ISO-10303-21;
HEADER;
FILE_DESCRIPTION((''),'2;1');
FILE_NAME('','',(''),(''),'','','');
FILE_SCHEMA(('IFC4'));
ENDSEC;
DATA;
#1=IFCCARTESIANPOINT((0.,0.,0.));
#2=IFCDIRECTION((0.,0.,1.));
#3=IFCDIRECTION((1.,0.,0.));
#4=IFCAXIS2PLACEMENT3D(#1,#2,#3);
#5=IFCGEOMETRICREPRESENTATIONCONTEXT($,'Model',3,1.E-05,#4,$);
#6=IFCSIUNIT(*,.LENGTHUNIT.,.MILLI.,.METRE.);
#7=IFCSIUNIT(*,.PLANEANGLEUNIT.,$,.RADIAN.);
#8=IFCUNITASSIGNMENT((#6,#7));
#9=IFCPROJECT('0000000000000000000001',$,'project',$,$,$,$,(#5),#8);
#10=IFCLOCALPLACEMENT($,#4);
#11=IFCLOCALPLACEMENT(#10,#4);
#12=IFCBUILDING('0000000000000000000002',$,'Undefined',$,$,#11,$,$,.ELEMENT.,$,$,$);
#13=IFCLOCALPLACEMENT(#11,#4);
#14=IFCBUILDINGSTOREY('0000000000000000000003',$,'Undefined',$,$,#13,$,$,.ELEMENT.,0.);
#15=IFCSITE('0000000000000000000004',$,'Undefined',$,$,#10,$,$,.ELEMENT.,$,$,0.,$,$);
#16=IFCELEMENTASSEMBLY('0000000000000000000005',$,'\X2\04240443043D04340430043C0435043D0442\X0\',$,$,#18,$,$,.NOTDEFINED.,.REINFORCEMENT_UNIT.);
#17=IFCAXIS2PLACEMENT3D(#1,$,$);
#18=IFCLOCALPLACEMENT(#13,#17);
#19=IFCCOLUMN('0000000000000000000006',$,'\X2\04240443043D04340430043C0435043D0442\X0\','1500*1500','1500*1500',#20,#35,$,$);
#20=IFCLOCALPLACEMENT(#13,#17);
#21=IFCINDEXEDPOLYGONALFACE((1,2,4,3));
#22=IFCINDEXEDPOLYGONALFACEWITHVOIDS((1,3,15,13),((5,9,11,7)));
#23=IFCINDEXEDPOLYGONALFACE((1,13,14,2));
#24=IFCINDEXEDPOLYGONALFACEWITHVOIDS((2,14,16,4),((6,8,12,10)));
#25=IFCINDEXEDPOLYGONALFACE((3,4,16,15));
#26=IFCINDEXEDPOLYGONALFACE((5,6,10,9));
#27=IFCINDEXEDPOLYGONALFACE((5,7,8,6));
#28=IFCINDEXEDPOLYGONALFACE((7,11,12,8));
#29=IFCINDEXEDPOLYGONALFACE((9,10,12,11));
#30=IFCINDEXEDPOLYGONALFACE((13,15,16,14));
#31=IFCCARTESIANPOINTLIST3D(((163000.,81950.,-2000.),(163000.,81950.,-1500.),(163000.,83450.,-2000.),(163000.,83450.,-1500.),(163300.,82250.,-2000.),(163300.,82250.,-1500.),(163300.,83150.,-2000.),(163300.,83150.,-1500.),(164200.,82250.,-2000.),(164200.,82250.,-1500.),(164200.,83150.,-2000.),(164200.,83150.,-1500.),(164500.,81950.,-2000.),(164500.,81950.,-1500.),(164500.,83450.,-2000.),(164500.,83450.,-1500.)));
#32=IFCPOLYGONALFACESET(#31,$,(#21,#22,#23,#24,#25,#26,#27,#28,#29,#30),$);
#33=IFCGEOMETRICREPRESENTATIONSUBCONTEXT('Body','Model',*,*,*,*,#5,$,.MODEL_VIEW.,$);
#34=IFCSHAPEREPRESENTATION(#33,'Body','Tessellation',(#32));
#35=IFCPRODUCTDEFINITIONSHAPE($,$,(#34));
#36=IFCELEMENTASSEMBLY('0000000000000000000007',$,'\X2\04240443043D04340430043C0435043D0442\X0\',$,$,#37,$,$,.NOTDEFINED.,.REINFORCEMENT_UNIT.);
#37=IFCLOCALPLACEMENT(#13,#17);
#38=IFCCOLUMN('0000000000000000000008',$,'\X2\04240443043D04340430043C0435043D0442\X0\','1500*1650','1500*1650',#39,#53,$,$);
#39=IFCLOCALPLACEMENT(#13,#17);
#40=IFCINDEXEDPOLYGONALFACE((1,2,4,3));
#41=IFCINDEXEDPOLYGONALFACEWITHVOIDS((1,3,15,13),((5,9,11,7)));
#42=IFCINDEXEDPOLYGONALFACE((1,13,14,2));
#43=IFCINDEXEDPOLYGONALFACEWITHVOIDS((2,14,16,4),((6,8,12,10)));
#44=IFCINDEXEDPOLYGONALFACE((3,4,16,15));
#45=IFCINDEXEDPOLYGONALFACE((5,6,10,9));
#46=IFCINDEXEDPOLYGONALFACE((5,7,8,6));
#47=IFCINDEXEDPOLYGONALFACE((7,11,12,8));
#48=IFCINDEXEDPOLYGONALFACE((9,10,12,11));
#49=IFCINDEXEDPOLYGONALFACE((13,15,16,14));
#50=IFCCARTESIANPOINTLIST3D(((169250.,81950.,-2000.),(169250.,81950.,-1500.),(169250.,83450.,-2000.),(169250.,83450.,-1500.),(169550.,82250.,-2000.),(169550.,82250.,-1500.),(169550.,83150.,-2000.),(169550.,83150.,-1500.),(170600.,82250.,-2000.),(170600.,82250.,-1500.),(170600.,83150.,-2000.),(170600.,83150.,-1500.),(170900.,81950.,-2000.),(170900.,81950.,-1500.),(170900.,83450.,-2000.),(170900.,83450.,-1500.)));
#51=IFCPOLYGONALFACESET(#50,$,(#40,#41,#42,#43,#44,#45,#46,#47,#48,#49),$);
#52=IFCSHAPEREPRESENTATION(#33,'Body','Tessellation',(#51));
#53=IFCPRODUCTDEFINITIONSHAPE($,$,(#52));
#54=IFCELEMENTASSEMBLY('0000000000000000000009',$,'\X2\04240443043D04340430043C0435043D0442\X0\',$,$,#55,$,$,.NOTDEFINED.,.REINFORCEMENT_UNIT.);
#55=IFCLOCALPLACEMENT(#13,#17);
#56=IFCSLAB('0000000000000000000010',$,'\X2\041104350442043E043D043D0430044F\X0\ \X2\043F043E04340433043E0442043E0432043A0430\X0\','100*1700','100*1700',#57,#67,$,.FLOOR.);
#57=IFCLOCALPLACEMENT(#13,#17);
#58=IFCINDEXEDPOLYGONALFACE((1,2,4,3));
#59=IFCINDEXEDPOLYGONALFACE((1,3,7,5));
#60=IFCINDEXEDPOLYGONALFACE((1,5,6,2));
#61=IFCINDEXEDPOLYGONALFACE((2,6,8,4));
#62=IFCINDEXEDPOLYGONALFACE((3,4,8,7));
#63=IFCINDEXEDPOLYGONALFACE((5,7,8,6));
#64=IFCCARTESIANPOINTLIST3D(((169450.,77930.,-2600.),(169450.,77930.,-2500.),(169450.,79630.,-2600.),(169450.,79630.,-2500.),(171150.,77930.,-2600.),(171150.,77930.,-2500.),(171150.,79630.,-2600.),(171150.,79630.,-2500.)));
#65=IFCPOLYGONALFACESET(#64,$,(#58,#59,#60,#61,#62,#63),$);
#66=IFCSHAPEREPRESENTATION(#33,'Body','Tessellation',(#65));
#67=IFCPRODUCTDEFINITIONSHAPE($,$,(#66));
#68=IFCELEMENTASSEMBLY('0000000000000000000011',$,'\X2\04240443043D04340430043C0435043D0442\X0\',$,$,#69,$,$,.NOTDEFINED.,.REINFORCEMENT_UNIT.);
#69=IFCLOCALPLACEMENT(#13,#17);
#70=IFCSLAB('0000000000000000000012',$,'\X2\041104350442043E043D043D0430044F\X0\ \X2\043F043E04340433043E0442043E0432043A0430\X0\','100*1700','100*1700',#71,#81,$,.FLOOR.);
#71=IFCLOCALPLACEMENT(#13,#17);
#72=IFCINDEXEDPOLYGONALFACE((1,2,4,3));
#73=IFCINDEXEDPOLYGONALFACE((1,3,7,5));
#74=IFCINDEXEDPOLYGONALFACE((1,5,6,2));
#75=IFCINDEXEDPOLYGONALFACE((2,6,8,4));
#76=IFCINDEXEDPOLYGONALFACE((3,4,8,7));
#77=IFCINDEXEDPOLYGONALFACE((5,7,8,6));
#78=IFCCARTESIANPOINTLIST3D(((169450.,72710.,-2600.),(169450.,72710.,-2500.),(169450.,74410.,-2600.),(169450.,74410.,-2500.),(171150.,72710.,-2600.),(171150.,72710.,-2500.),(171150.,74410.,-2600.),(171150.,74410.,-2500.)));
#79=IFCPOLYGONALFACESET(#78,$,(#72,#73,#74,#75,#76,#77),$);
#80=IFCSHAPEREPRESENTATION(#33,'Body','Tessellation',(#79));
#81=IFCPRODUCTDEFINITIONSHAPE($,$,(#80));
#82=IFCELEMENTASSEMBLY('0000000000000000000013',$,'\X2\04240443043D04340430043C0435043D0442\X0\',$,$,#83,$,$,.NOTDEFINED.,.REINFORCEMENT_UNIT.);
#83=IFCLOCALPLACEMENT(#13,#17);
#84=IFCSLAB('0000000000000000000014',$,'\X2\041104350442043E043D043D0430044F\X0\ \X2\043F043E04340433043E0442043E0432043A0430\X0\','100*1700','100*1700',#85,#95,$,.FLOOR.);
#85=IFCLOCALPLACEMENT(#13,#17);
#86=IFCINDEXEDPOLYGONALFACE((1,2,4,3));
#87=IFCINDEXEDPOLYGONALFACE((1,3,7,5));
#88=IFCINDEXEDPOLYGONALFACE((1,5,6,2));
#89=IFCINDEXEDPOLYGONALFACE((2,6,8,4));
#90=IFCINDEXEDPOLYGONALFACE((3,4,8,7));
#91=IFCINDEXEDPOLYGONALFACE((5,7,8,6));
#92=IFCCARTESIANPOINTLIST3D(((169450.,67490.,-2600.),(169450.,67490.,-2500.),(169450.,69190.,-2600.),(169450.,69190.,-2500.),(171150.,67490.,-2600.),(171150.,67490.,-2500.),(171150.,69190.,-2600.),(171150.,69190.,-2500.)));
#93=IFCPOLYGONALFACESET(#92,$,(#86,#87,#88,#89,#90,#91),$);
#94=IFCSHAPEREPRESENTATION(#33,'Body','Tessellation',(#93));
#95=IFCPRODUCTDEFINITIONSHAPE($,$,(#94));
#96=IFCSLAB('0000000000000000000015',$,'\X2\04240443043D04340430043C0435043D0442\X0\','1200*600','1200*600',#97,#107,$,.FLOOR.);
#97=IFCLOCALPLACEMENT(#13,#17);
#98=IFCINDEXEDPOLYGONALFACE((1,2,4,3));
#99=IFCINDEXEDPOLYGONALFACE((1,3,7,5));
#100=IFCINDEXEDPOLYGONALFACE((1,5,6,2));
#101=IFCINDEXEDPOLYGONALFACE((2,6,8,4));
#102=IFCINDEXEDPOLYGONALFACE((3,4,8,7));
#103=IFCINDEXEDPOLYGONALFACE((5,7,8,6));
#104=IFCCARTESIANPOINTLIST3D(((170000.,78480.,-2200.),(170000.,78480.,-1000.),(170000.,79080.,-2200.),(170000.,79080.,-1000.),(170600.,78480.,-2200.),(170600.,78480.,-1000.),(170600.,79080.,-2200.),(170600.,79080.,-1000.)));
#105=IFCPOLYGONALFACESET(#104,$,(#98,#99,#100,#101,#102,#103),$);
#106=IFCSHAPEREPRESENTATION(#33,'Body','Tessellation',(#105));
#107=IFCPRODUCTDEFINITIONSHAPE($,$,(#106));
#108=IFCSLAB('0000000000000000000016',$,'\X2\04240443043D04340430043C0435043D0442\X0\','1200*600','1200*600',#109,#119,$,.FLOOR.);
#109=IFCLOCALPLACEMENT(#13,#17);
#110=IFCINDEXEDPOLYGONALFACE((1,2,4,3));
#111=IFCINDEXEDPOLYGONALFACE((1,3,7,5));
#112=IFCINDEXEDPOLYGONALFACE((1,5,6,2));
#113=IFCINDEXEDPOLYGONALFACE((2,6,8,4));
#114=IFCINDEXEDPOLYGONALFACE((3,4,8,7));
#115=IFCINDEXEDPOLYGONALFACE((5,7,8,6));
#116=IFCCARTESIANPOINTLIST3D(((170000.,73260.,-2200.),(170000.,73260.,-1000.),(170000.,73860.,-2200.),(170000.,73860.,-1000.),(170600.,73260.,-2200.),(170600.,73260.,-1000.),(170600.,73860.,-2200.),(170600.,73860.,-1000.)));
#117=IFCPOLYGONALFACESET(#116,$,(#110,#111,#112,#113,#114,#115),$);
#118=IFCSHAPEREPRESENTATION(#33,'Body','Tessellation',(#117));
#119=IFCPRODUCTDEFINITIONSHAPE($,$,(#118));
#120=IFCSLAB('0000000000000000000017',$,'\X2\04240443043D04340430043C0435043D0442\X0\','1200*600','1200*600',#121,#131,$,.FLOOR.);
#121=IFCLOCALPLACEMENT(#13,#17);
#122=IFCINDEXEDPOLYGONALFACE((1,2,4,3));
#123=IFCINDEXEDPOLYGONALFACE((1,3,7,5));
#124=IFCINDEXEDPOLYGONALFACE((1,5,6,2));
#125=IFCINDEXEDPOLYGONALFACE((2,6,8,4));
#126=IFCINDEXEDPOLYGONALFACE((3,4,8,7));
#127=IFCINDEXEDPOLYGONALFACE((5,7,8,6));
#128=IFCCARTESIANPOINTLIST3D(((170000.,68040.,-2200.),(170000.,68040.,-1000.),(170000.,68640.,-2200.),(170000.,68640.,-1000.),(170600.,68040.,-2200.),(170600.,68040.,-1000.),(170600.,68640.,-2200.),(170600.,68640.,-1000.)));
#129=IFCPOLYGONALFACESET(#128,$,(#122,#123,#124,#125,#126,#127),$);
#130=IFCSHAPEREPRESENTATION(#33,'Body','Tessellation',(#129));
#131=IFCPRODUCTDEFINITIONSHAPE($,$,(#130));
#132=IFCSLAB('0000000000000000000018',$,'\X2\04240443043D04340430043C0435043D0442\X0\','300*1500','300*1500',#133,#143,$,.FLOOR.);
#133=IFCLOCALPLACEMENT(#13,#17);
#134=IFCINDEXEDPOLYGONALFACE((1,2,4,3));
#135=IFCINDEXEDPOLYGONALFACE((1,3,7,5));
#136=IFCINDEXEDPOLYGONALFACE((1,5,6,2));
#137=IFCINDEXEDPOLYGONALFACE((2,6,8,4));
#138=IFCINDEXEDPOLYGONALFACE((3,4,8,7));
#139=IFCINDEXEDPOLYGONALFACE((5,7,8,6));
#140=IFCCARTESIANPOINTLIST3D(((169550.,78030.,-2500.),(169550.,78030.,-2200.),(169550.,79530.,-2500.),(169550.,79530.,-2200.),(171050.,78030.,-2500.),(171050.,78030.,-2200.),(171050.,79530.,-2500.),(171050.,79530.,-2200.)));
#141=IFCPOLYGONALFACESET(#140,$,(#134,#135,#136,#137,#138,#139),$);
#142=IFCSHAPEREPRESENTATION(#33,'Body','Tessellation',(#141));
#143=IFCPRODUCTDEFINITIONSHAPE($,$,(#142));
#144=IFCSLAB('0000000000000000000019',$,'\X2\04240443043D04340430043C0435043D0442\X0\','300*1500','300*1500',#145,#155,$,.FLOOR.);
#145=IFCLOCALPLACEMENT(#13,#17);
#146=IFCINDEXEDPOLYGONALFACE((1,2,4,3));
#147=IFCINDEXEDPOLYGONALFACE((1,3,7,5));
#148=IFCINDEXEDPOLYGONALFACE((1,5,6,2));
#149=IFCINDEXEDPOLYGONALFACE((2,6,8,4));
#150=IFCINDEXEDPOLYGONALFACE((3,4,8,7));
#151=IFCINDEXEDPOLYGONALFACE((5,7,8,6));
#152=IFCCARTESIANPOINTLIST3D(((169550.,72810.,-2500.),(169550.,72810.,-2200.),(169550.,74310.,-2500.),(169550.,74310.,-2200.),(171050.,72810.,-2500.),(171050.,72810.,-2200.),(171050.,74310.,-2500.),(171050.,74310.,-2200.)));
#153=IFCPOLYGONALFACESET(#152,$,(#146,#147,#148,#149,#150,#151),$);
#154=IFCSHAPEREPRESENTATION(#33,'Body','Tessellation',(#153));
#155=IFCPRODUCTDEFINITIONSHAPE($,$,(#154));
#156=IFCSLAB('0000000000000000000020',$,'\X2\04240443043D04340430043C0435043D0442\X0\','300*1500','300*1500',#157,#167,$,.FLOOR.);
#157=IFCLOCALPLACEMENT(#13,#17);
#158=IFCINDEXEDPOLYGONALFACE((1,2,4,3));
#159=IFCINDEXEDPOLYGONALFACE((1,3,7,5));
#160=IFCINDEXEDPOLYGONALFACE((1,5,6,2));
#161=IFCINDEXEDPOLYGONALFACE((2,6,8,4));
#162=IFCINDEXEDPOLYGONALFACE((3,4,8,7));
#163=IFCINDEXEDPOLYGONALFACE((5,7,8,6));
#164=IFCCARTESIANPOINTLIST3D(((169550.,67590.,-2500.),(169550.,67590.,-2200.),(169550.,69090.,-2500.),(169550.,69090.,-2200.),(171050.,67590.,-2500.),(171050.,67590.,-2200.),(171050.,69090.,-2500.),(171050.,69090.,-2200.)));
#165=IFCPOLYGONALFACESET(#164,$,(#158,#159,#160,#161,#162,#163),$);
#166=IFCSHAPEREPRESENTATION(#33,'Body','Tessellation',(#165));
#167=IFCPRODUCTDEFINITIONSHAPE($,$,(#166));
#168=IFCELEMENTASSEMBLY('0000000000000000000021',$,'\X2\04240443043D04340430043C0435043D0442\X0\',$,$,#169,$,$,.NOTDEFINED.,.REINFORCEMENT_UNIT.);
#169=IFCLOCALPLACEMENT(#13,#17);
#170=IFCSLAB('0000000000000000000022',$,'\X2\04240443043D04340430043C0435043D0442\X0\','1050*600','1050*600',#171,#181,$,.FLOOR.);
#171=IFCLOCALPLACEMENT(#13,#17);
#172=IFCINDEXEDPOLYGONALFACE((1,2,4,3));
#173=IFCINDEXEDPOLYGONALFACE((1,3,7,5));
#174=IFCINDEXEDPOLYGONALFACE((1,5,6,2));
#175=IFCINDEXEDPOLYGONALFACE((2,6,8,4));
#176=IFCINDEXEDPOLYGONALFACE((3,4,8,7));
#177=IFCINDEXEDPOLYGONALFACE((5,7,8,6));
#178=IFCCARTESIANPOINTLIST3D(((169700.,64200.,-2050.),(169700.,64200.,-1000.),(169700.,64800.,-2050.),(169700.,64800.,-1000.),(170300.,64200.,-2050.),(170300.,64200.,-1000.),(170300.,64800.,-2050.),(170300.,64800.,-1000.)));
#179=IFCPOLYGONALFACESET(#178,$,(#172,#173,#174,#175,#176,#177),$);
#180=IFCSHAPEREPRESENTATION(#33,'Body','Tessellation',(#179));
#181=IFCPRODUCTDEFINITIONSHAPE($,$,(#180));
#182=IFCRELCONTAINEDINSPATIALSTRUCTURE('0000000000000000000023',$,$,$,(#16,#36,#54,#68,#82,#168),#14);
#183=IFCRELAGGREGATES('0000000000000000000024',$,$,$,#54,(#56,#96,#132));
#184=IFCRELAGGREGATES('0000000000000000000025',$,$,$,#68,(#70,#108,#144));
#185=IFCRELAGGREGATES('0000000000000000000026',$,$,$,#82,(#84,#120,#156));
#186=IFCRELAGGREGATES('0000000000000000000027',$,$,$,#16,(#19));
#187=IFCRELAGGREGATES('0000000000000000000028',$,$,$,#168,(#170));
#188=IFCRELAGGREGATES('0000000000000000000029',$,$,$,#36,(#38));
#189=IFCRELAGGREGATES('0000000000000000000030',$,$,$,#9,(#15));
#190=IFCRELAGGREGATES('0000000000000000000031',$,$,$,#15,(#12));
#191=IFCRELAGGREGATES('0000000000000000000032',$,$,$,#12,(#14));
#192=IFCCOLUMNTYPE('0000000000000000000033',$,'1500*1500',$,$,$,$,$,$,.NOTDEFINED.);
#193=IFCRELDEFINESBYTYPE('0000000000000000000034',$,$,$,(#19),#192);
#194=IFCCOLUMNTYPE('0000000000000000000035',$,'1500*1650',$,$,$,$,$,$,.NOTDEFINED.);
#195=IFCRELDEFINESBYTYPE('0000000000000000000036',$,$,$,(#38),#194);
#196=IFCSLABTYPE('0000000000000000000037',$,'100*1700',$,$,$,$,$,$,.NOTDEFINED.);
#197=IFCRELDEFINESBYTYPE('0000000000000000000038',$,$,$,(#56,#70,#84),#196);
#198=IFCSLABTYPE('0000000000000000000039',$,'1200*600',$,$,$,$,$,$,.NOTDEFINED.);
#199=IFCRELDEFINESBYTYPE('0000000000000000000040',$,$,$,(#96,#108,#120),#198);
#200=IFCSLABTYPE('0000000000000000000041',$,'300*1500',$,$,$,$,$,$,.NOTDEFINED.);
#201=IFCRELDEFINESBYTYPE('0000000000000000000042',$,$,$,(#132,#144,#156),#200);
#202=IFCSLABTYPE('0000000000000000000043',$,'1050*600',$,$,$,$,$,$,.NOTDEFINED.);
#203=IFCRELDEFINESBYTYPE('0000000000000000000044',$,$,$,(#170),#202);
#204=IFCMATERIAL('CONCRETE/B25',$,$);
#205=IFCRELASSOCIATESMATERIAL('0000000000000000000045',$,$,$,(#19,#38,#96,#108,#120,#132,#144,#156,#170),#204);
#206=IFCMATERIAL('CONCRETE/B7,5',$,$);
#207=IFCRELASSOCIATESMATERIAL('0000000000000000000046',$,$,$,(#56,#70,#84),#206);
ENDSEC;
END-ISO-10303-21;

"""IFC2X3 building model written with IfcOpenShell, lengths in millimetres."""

from ifc_helpers import new_model, si_unit, frame, origin_with_axes, origin_2d_with_axis, place, context, subcontext, project, spatial, polyline, rectangle, outline, extrude, boolean, material, type_object, element, aggregate, save


model = new_model("IFC2X3")

# Units and contexts
model_context = context("Model", 3, precision=1e-05, world=origin_with_axes())
body_context = subcontext(model_context, "Body", "Model", "MODEL_VIEW")
ifc_project = project(units=[si_unit("LENGTHUNIT", "METRE", prefix="MILLI"), si_unit("PLANEANGLEUNIT", "RADIAN")], contexts=[model_context])

# Site, building, storey
site_placement = place(None, origin_with_axes())
site = spatial("IfcSite", under=ifc_project, at=site_placement, Name="Undefined", CompositionType="ELEMENT", RefElevation=0.0)
building_placement = place(site_placement, origin_with_axes())
building = spatial("IfcBuilding", under=site, at=building_placement, Name="Undefined", CompositionType="ELEMENT")
storey_placement = place(building_placement, origin_with_axes())
storey = spatial("IfcBuildingStorey", under=building, at=storey_placement, Name="Undefined", CompositionType="ELEMENT", Elevation=0.0)

# Element assemblies, columns
assembly_1_placement = place(storey_placement, origin_with_axes())
assembly_1 = element("IfcElementAssembly", 1, at=assembly_1_placement, inside=storey, Name="Фундамент", AssemblyPlace="NOTDEFINED", PredefinedType="REINFORCEMENT_UNIT")
ifc_material_1 = material(Name="CONCRETE/B25")
column_type_1 = type_object("IfcColumnType", Name="1500*1500", PredefinedType="NOTDEFINED")
column_1_placement = place(assembly_1_placement, frame((163750.0, 82700.0, -2000.0), z_axis=(0.0, 0.0, 1.0), x_axis=(0.0, -1.0, 0.0)))
column_1 = element("IfcColumn", 2, at=column_1_placement, type_object=column_type_1, material=ifc_material_1, Name="Фундамент", Description="1500*1500", ObjectType="1500*1500", context=body_context, shape_type="CSG", body=[
    boolean("DIFFERENCE", extrude(rectangle(XDim=1500.0, YDim=1500.0, at=origin_2d_with_axis()), frame((0.0, 0.0, 500.0), z_axis=(0.0, 0.0, -1.0), x_axis=(0.0, 1.0, 0.0)), (0.0, 0.0, 1.0), 500.0), extrude(outline(polyline([(0.0, 0.0), (900.0, 0.0), (900.0, 900.0), (0.0, 900.0), (0.0, 0.0)])), frame((-450.0, -450.0, -100.0), z_axis=(0.0, 0.0, 1.0), x_axis=(1.0, 0.0, 0.0)), (0.0, 0.0, 1.0), 700.0)),
])
assembly_2_placement = place(storey_placement, origin_with_axes())
assembly_2 = element("IfcElementAssembly", 3, at=assembly_2_placement, inside=storey, Name="Фундамент", AssemblyPlace="NOTDEFINED", PredefinedType="REINFORCEMENT_UNIT")
column_type_2 = type_object("IfcColumnType", Name="1500*1650", PredefinedType="NOTDEFINED")
column_2_placement = place(assembly_2_placement, frame((170075.0, 82700.0, -2000.0), z_axis=(0.0, 0.0, 1.0), x_axis=(0.0, -1.0, 0.0)))
column_2 = element("IfcColumn", 4, at=column_2_placement, type_object=column_type_2, material=ifc_material_1, Name="Фундамент", Description="1500*1650", ObjectType="1500*1650", context=body_context, shape_type="CSG", body=[
    boolean("DIFFERENCE", extrude(rectangle(XDim=1650.0, YDim=1500.0, at=origin_2d_with_axis()), frame((0.0, 0.0, 500.0), z_axis=(0.0, 0.0, -1.0), x_axis=(0.0, 1.0, 0.0)), (0.0, 0.0, 1.0), 500.0), extrude(outline(polyline([(0.0, 0.0), (900.0, 0.0), (900.0, 1050.0), (0.0, 1050.0), (0.0, 0.0)])), frame((-450.0, -525.0, -100.0), z_axis=(0.0, 0.0, 1.0), x_axis=(1.0, 0.0, 0.0)), (0.0, 0.0, 1.0), 700.0)),
])

# Element assemblies, slabs
assembly_3_placement = place(storey_placement, origin_with_axes())
assembly_3 = element("IfcElementAssembly", 5, at=assembly_3_placement, inside=storey, Name="Фундамент", AssemblyPlace="NOTDEFINED", PredefinedType="REINFORCEMENT_UNIT")
ifc_material_2 = material(Name="CONCRETE/B7,5")
slab_type_1 = type_object("IfcSlabType", Name="100*1700", PredefinedType="NOTDEFINED")
slab_1_placement = place(assembly_3_placement, frame((169450.0, 79630.0, -2550.0), z_axis=(0.0, 0.0, 1.0), x_axis=(0.0, -1.0, 0.0)))
slab_1 = element("IfcSlab", 6, at=slab_1_placement, type_object=slab_type_1, material=ifc_material_2, Name="Бетонная подготовка", Description="100*1700", ObjectType="100*1700", PredefinedType="FLOOR", context=body_context, shape_type="SweptSolid", body=[
    extrude(outline(polyline([(0.0, 0.0), (1700.0, 0.0), (1700.0, 1700.0), (0.0, 1700.0), (0.0, 0.0)])), frame((0.0, 0.0, -50.0), z_axis=(0.0, 0.0, 1.0), x_axis=(1.0, 0.0, 0.0)), (0.0, 0.0, 1.0), 100.0),
])
assembly_4_placement = place(storey_placement, origin_with_axes())
assembly_4 = element("IfcElementAssembly", 7, at=assembly_4_placement, inside=storey, Name="Фундамент", AssemblyPlace="NOTDEFINED", PredefinedType="REINFORCEMENT_UNIT")
slab_2_placement = place(assembly_4_placement, frame((169450.0, 74410.0, -2550.0), z_axis=(0.0, 0.0, 1.0), x_axis=(0.0, -1.0, 0.0)))
slab_2 = element("IfcSlab", 8, at=slab_2_placement, type_object=slab_type_1, material=ifc_material_2, Name="Бетонная подготовка", Description="100*1700", ObjectType="100*1700", PredefinedType="FLOOR", context=body_context, shape_type="SweptSolid", body=[
    extrude(outline(polyline([(0.0, 0.0), (1700.0, 0.0), (1700.0, 1700.0), (0.0, 1700.0), (0.0, 0.0)])), frame((0.0, 0.0, -50.0), z_axis=(0.0, 0.0, 1.0), x_axis=(1.0, 0.0, 0.0)), (0.0, 0.0, 1.0), 100.0),
])
assembly_5_placement = place(storey_placement, origin_with_axes())
assembly_5 = element("IfcElementAssembly", 9, at=assembly_5_placement, inside=storey, Name="Фундамент", AssemblyPlace="NOTDEFINED", PredefinedType="REINFORCEMENT_UNIT")
slab_3_placement = place(assembly_5_placement, frame((169450.0, 69190.0, -2550.0), z_axis=(0.0, 0.0, 1.0), x_axis=(0.0, -1.0, 0.0)))
slab_3 = element("IfcSlab", 10, at=slab_3_placement, type_object=slab_type_1, material=ifc_material_2, Name="Бетонная подготовка", Description="100*1700", ObjectType="100*1700", PredefinedType="FLOOR", context=body_context, shape_type="SweptSolid", body=[
    extrude(outline(polyline([(0.0, 0.0), (1700.0, 0.0), (1700.0, 1700.0), (0.0, 1700.0), (0.0, 0.0)])), frame((0.0, 0.0, -50.0), z_axis=(0.0, 0.0, 1.0), x_axis=(1.0, 0.0, 0.0)), (0.0, 0.0, 1.0), 100.0),
])

# Slabs
slab_type_2 = type_object("IfcSlabType", Name="1200*600", PredefinedType="NOTDEFINED")
slab_4_placement = place(assembly_3_placement, frame((170000.0, 79080.0, -1600.0), z_axis=(0.0, 0.0, 1.0), x_axis=(0.0, -1.0, 0.0)))
slab_4 = element("IfcSlab", 11, at=slab_4_placement, type_object=slab_type_2, material=ifc_material_1, Name="Фундамент", Description="1200*600", ObjectType="1200*600", PredefinedType="FLOOR", context=body_context, shape_type="SweptSolid", body=[
    extrude(outline(polyline([(0.0, 0.0), (600.0, 0.0), (600.0, 600.0), (0.0, 600.0), (0.0, 0.0)])), frame((0.0, 0.0, -600.0), z_axis=(0.0, 0.0, 1.0), x_axis=(1.0, 0.0, 0.0)), (0.0, 0.0, 1.0), 1200.0),
])
slab_5_placement = place(assembly_4_placement, frame((170000.0, 73860.0, -1600.0), z_axis=(0.0, 0.0, 1.0), x_axis=(0.0, -1.0, 0.0)))
slab_5 = element("IfcSlab", 12, at=slab_5_placement, type_object=slab_type_2, material=ifc_material_1, Name="Фундамент", Description="1200*600", ObjectType="1200*600", PredefinedType="FLOOR", context=body_context, shape_type="SweptSolid", body=[
    extrude(outline(polyline([(0.0, 0.0), (600.0, 0.0), (600.0, 600.0), (0.0, 600.0), (0.0, 0.0)])), frame((0.0, 0.0, -600.0), z_axis=(0.0, 0.0, 1.0), x_axis=(1.0, 0.0, 0.0)), (0.0, 0.0, 1.0), 1200.0),
])
slab_6_placement = place(assembly_5_placement, frame((170000.0, 68640.0, -1600.0), z_axis=(0.0, 0.0, 1.0), x_axis=(0.0, -1.0, 0.0)))
slab_6 = element("IfcSlab", 13, at=slab_6_placement, type_object=slab_type_2, material=ifc_material_1, Name="Фундамент", Description="1200*600", ObjectType="1200*600", PredefinedType="FLOOR", context=body_context, shape_type="SweptSolid", body=[
    extrude(outline(polyline([(0.0, 0.0), (600.0, 0.0), (600.0, 600.0), (0.0, 600.0), (0.0, 0.0)])), frame((0.0, 0.0, -600.0), z_axis=(0.0, 0.0, 1.0), x_axis=(1.0, 0.0, 0.0)), (0.0, 0.0, 1.0), 1200.0),
])
slab_type_3 = type_object("IfcSlabType", Name="300*1500", PredefinedType="NOTDEFINED")
slab_7_placement = place(assembly_3_placement, frame((169550.0, 79530.0, -2350.0), z_axis=(0.0, 0.0, 1.0), x_axis=(0.0, -1.0, 0.0)))
slab_7 = element("IfcSlab", 14, at=slab_7_placement, type_object=slab_type_3, material=ifc_material_1, Name="Фундамент", Description="300*1500", ObjectType="300*1500", PredefinedType="FLOOR", context=body_context, shape_type="SweptSolid", body=[
    extrude(outline(polyline([(0.0, 0.0), (1500.0, 0.0), (1500.0, 1500.0), (0.0, 1500.0), (0.0, 0.0)])), frame((0.0, 0.0, -150.0), z_axis=(0.0, 0.0, 1.0), x_axis=(1.0, 0.0, 0.0)), (0.0, 0.0, 1.0), 300.0),
])
aggregate(assembly_3, [slab_1, slab_4, slab_7])
slab_8_placement = place(assembly_4_placement, frame((169550.0, 74310.0, -2350.0), z_axis=(0.0, 0.0, 1.0), x_axis=(0.0, -1.0, 0.0)))
slab_8 = element("IfcSlab", 15, at=slab_8_placement, type_object=slab_type_3, material=ifc_material_1, Name="Фундамент", Description="300*1500", ObjectType="300*1500", PredefinedType="FLOOR", context=body_context, shape_type="SweptSolid", body=[
    extrude(outline(polyline([(0.0, 0.0), (1500.0, 0.0), (1500.0, 1500.0), (0.0, 1500.0), (0.0, 0.0)])), frame((0.0, 0.0, -150.0), z_axis=(0.0, 0.0, 1.0), x_axis=(1.0, 0.0, 0.0)), (0.0, 0.0, 1.0), 300.0),
])
aggregate(assembly_4, [slab_2, slab_5, slab_8])
slab_9_placement = place(assembly_5_placement, frame((169550.0, 69090.0, -2350.0), z_axis=(0.0, 0.0, 1.0), x_axis=(0.0, -1.0, 0.0)))
slab_9 = element("IfcSlab", 16, at=slab_9_placement, type_object=slab_type_3, material=ifc_material_1, Name="Фундамент", Description="300*1500", ObjectType="300*1500", PredefinedType="FLOOR", context=body_context, shape_type="SweptSolid", body=[
    extrude(outline(polyline([(0.0, 0.0), (1500.0, 0.0), (1500.0, 1500.0), (0.0, 1500.0), (0.0, 0.0)])), frame((0.0, 0.0, -150.0), z_axis=(0.0, 0.0, 1.0), x_axis=(1.0, 0.0, 0.0)), (0.0, 0.0, 1.0), 300.0),
])
aggregate(assembly_5, [slab_3, slab_6, slab_9])

# Element assembly, slab
assembly_6_placement = place(storey_placement, origin_with_axes())
assembly_6 = element("IfcElementAssembly", 17, at=assembly_6_placement, inside=storey, Name="Фундамент", AssemblyPlace="NOTDEFINED", PredefinedType="REINFORCEMENT_UNIT")
slab_type_4 = type_object("IfcSlabType", Name="1050*600", PredefinedType="NOTDEFINED")
slab_10_placement = place(assembly_6_placement, frame((169700.0, 64800.0, -1525.0), z_axis=(0.0, 0.0, 1.0), x_axis=(0.0, -1.0, 0.0)))
slab_10 = element("IfcSlab", 18, at=slab_10_placement, type_object=slab_type_4, material=ifc_material_1, Name="Фундамент", Description="1050*600", ObjectType="1050*600", PredefinedType="FLOOR", context=body_context, shape_type="SweptSolid", body=[
    extrude(outline(polyline([(0.0, 0.0), (600.0, 0.0), (600.0, 600.0), (0.0, 600.0), (0.0, 0.0)])), frame((0.0, 0.0, -525.0), z_axis=(0.0, 0.0, 1.0), x_axis=(1.0, 0.0, 0.0)), (0.0, 0.0, 1.0), 1050.0),
])

aggregate(assembly_1, [column_1])
aggregate(assembly_6, [slab_10])
aggregate(assembly_2, [column_2])

save(model, "model.ifc")
